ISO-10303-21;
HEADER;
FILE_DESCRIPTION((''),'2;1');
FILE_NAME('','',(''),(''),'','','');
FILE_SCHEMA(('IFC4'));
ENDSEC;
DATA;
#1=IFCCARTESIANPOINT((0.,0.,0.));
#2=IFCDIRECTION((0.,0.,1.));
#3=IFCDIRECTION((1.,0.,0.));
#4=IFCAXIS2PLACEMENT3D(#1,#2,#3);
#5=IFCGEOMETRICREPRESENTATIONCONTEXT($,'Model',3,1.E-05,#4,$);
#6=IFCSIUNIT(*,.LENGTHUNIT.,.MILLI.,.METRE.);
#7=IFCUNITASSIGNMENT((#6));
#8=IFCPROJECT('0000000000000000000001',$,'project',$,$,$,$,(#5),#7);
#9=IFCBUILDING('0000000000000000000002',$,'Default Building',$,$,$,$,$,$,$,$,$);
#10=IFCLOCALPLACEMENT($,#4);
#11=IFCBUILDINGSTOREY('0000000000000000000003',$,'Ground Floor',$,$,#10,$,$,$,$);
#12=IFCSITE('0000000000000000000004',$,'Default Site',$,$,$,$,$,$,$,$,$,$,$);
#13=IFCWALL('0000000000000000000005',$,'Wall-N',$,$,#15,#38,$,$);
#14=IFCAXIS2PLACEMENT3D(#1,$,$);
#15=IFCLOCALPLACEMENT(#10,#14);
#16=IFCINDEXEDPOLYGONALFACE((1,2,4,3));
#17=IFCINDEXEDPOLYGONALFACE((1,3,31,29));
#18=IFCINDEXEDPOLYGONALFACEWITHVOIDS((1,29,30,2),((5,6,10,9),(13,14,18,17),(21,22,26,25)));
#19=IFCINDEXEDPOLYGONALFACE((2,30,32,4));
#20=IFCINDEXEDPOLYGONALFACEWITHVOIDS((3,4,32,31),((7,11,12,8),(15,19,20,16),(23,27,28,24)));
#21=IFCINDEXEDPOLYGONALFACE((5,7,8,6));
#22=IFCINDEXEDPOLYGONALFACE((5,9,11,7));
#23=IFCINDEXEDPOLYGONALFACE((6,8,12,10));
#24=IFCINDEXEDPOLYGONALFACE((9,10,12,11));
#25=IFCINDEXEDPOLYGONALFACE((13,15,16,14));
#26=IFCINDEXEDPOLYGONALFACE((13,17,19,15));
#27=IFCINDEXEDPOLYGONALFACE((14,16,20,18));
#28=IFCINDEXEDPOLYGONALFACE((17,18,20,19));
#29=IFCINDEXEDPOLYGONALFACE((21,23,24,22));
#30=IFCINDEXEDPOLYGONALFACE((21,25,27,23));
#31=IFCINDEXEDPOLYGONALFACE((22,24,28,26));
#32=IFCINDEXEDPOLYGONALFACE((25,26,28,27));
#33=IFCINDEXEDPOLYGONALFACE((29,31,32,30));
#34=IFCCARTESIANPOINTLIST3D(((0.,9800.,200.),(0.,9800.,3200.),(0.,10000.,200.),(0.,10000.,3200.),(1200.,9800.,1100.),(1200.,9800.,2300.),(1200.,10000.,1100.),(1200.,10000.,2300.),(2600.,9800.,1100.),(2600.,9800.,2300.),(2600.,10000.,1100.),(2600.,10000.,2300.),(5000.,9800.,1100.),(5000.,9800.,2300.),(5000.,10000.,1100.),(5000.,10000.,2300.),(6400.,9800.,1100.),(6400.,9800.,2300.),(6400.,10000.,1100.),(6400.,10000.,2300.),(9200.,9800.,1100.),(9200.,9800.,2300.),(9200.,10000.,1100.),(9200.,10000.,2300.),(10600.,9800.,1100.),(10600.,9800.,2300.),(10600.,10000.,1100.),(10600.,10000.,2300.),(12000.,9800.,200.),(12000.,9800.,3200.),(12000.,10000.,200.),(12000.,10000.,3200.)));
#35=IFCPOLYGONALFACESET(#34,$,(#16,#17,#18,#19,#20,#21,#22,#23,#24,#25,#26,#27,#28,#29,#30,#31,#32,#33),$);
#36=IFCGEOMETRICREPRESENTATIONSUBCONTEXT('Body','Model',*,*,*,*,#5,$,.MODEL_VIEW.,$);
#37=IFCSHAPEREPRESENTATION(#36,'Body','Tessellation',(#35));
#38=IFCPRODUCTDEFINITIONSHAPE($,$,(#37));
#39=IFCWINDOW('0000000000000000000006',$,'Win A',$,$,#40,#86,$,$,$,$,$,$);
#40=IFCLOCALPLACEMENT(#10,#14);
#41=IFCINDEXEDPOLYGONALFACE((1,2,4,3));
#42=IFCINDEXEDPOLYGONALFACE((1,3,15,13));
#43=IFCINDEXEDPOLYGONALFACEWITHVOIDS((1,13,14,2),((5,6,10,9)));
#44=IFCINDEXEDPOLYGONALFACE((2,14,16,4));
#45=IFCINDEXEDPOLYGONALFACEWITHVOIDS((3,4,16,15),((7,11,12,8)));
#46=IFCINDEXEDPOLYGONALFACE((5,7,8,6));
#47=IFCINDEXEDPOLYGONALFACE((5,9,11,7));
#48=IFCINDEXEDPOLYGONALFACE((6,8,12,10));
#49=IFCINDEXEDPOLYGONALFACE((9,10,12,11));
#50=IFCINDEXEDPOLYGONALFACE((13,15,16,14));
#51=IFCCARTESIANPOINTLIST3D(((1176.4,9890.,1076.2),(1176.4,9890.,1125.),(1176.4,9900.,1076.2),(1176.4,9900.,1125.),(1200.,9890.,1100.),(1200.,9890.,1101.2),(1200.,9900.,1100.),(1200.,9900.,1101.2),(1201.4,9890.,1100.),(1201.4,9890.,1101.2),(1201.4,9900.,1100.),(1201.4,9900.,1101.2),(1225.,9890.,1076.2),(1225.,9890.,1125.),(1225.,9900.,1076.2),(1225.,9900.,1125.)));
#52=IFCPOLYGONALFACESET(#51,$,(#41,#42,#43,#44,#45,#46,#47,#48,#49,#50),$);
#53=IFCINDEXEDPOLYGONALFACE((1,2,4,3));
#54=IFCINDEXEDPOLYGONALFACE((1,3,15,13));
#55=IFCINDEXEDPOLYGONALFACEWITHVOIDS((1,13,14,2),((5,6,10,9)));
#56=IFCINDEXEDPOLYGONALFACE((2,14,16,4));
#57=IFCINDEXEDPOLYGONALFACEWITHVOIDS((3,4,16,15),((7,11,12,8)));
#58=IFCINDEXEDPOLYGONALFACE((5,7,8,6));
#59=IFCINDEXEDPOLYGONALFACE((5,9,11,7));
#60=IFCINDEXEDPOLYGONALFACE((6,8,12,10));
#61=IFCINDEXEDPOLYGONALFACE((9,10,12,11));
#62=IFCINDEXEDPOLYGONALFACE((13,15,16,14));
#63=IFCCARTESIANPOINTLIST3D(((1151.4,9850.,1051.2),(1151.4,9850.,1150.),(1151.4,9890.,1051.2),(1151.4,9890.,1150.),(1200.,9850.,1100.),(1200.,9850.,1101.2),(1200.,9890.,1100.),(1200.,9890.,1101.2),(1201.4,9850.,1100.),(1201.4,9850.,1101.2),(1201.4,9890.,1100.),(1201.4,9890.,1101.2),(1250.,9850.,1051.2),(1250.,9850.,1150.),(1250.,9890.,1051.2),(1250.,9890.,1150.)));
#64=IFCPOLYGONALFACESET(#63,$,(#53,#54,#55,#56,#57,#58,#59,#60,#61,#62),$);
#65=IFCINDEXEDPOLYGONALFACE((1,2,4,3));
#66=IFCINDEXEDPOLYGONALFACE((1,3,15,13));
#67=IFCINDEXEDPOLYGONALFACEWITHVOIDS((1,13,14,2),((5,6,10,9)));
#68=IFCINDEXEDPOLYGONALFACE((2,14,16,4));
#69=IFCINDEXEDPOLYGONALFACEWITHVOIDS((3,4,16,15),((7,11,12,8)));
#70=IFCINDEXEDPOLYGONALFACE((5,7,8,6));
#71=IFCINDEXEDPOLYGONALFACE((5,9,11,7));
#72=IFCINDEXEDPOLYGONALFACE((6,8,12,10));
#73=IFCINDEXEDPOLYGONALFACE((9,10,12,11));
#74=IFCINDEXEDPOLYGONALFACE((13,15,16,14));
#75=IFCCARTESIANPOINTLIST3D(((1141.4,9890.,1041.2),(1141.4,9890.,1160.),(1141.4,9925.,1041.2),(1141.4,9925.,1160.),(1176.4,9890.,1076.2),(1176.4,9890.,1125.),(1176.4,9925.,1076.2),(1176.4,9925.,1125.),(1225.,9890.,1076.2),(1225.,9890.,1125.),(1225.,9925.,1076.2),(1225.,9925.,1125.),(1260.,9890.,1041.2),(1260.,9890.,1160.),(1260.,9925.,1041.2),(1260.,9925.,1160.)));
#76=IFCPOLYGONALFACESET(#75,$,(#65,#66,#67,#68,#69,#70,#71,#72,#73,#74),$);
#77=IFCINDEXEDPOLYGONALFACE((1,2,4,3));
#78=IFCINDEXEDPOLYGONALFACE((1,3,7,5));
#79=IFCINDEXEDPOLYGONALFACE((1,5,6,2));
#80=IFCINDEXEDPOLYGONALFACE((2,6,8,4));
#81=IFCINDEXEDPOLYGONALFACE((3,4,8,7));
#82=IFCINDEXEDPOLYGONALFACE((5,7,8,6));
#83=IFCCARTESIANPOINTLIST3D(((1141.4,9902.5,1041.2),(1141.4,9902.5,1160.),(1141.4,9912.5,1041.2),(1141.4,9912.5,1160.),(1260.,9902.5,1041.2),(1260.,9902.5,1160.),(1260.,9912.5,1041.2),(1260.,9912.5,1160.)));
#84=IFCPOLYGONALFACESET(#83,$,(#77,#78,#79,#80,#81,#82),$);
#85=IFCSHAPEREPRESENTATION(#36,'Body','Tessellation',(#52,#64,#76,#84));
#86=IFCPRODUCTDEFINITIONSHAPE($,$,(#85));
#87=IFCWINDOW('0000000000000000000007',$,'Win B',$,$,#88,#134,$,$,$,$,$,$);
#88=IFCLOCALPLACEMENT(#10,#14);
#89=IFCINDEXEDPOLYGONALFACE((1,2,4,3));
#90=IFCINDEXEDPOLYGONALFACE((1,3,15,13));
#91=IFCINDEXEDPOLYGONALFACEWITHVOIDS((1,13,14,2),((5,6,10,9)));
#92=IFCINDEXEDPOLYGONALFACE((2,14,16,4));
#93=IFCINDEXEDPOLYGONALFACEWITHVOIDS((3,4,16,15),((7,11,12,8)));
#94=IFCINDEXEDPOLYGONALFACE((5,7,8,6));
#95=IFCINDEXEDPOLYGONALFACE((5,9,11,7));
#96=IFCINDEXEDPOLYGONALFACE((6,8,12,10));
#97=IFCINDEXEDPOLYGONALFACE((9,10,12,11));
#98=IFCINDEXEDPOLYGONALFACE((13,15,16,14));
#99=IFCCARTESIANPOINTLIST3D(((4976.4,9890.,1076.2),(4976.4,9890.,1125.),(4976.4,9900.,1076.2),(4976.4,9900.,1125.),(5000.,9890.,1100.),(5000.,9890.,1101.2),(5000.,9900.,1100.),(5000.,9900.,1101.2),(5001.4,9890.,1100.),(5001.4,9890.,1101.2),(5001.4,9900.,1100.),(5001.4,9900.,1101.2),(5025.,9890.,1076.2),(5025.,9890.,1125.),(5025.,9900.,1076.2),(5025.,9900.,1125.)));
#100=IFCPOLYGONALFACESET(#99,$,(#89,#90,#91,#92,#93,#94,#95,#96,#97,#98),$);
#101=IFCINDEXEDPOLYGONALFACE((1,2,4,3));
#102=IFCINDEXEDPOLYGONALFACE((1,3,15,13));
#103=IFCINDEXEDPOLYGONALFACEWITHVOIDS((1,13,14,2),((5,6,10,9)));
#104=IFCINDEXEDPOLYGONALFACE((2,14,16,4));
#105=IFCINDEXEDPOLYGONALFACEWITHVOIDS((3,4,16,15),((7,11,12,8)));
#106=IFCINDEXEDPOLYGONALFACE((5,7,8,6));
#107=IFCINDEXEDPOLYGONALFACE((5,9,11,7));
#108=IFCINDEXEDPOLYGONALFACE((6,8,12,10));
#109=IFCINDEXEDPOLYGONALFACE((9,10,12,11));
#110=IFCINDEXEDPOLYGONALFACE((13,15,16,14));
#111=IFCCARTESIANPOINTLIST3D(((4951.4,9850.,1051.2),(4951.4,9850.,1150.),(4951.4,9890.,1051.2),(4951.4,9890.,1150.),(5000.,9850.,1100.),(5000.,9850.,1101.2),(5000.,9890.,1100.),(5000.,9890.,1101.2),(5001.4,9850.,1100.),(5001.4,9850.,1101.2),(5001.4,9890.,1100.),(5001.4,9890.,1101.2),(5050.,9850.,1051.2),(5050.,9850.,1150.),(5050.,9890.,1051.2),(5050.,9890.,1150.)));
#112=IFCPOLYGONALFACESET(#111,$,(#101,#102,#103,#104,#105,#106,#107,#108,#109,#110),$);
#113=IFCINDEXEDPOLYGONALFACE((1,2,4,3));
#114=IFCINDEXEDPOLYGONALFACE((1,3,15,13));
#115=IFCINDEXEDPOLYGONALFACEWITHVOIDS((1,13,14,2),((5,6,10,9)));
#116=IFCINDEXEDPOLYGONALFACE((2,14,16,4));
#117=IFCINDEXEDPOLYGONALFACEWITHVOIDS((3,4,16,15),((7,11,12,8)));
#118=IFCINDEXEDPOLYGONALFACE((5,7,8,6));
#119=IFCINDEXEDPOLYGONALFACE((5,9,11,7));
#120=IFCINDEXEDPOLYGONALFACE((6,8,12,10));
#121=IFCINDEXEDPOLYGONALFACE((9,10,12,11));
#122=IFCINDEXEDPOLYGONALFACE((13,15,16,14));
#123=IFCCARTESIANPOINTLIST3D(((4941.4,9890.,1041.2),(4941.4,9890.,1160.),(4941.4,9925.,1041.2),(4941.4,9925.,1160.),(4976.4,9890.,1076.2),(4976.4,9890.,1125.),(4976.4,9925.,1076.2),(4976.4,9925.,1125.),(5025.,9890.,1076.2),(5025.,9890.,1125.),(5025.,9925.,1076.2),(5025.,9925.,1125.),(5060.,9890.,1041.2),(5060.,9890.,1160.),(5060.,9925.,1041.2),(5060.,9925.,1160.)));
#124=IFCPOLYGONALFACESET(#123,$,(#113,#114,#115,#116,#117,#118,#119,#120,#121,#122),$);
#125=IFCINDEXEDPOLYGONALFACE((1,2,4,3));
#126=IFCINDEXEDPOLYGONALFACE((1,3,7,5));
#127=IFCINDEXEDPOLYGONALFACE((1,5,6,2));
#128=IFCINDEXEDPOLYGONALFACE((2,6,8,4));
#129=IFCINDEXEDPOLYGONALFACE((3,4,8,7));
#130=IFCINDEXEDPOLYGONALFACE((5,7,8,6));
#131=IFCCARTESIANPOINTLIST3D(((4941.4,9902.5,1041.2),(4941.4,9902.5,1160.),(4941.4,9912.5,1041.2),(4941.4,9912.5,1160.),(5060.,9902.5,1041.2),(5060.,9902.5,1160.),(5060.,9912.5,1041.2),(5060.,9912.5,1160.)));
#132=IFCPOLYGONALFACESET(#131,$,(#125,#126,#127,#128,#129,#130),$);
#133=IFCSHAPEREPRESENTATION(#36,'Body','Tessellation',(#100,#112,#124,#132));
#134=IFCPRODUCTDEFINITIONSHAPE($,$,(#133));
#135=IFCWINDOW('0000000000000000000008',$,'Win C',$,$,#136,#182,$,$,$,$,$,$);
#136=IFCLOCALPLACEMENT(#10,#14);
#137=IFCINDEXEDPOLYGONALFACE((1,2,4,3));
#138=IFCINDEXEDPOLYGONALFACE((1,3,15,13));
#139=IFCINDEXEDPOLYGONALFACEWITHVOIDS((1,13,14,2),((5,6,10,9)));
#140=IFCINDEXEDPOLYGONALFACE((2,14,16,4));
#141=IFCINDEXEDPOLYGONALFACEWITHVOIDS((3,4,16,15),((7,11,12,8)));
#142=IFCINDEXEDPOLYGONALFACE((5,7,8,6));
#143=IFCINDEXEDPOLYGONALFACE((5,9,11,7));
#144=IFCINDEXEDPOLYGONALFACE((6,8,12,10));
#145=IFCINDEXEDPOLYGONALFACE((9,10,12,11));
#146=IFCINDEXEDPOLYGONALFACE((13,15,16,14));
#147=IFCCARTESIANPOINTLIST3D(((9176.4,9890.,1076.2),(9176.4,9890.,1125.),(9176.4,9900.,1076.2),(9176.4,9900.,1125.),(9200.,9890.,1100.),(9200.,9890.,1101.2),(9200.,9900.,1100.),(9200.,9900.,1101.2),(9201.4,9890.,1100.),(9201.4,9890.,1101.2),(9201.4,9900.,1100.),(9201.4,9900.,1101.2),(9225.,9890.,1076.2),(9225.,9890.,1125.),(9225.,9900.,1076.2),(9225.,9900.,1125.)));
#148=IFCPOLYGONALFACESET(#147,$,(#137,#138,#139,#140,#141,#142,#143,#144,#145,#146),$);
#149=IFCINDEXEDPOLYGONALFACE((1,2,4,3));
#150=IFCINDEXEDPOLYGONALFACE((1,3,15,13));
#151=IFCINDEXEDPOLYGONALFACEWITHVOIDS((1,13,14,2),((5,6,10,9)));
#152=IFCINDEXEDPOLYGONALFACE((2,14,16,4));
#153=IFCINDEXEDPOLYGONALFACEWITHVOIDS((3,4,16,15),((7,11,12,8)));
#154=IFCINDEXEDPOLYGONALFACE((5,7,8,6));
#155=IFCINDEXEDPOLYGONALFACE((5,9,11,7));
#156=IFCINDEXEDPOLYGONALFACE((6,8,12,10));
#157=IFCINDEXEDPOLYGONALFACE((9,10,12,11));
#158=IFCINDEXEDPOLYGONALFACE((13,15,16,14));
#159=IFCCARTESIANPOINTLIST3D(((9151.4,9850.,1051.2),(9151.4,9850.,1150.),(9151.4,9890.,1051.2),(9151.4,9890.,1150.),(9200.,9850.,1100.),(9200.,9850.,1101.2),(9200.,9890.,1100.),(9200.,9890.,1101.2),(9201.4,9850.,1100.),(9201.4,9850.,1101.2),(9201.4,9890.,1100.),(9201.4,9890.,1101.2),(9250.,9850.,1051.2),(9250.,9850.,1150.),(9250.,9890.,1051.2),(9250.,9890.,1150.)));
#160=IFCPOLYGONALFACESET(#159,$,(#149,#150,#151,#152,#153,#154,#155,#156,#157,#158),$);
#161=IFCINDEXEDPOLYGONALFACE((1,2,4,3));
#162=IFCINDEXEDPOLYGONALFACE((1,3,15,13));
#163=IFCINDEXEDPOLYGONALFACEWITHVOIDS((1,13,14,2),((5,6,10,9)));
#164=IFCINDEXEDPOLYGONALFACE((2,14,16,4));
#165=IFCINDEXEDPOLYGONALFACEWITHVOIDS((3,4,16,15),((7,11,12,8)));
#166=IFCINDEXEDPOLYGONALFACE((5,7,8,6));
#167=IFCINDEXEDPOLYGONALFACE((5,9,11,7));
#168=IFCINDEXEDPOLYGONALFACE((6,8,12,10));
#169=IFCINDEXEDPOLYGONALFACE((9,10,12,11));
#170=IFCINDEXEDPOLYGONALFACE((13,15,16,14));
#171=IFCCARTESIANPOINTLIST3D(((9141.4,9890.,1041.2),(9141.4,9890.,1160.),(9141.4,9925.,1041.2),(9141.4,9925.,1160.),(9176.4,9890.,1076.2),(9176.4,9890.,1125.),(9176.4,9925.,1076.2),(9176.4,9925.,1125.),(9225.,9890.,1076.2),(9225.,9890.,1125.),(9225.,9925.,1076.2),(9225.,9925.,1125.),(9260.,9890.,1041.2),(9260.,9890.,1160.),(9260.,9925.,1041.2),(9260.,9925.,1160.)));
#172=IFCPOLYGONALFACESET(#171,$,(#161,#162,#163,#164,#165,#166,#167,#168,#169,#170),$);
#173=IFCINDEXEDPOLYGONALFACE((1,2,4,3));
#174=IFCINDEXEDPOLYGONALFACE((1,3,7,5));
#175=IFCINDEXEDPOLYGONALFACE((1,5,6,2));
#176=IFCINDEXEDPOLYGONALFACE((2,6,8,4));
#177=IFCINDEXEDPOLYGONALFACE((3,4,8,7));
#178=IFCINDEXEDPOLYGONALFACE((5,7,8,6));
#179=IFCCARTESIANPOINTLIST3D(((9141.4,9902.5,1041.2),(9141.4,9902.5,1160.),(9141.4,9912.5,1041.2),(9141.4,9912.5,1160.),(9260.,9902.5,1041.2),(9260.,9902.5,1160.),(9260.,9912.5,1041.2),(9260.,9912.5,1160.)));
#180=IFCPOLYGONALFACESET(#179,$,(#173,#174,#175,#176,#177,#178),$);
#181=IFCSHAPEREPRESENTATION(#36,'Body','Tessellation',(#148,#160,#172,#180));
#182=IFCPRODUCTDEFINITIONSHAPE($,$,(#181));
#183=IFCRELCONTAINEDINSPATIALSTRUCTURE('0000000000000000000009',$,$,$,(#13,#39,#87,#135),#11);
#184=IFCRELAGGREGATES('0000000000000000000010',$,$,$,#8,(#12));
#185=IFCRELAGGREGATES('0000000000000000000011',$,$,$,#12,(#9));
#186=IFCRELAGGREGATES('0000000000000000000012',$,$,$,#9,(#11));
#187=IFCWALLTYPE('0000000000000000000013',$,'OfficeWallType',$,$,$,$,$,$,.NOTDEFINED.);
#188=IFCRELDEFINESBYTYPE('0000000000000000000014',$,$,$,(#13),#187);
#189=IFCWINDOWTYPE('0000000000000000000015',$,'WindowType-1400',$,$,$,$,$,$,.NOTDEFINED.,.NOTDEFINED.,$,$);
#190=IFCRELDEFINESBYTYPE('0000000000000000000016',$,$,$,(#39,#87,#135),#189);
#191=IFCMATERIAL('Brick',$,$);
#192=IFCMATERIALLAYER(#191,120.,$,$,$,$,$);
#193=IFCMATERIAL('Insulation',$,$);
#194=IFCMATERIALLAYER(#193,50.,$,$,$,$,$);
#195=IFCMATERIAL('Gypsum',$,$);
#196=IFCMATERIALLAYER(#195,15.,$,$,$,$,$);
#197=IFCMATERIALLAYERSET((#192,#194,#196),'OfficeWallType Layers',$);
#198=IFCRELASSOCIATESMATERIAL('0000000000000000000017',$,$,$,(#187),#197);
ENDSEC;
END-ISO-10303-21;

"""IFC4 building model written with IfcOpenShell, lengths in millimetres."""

from ifc_helpers import new_model, si_unit, frame, origin_with_axes, place, context, subcontext, project, spatial, line, indexed_curve, outline, extrude, material, layer, layer_set, type_object, element, fill, save


model = new_model("IFC4")

# Units and contexts
model_context = context("Model", 3, precision=1e-05, world=origin_with_axes())
body_context = subcontext(model_context, "Body", "Model", "MODEL_VIEW")
ifc_project = project(units=[si_unit("LENGTHUNIT", "METRE", prefix="MILLI")], contexts=[model_context])

# Site, building, storey
site = spatial("IfcSite", under=ifc_project, Name="Default Site")
building = spatial("IfcBuilding", under=site, Name="Default Building")
storey_placement = place(None, origin_with_axes())
storey = spatial("IfcBuildingStorey", under=building, at=storey_placement, Name="Ground Floor")

# Shared definitions
ifc_material_1 = material(Name="Brick")
ifc_layer_1 = layer(ifc_material_1, 120.0)
ifc_material_2 = material(Name="Insulation")
ifc_layer_2 = layer(ifc_material_2, 50.0)
ifc_material_3 = material(Name="Gypsum")
ifc_layer_3 = layer(ifc_material_3, 15.0)
ifc_layer_set_1 = layer_set([ifc_layer_1, ifc_layer_2, ifc_layer_3], Name="OfficeWallType Layers")
wall_type = type_object("IfcWallType", Name="OfficeWallType", PredefinedType="NOTDEFINED", material=ifc_layer_set_1)

# Wall, openings, windows
wall_1_placement = place(storey_placement, frame((0.0, 0.0, 200.0), z_axis=(0.0, 0.0, 1.0), x_axis=(1.0, 0.0, 0.0)))
wall_1 = element("IfcWall", 1, at=wall_1_placement, inside=storey, type_object=wall_type, Name="Wall-N", context=body_context, shape_type="SweptSolid", body=[
    extrude(outline(indexed_curve([(0.0, 9800.0), (12000.0, 9800.0), (12000.0, 10000.0), (0.0, 10000.0), (0.0, 9800.0)])), None, (0.0, 0.0, 1.0), 3000.0),
])
opening_1_placement = place(wall_1_placement, frame((0.0, 0.0, 900.0), z_axis=(0.0, 0.0, 1.0), x_axis=(1.0, 0.0, 0.0)))
opening_1 = element("IfcOpeningElement", 2, at=opening_1_placement, cuts=wall_1, context=body_context, shape_type="SweptSolid", body=[
    extrude(outline(indexed_curve([(1200.0, 9800.0), (2600.0, 9800.0), (2600.0, 10000.0), (1200.0, 10000.0), (1200.0, 9800.0)])), None, (0.0, 0.0, 1.0), 1200.0),
])
opening_2_placement = place(wall_1_placement, frame((0.0, 0.0, 900.0), z_axis=(0.0, 0.0, 1.0), x_axis=(1.0, 0.0, 0.0)))
opening_2 = element("IfcOpeningElement", 3, at=opening_2_placement, cuts=wall_1, context=body_context, shape_type="SweptSolid", body=[
    extrude(outline(indexed_curve([(5000.0, 9800.0), (6400.0, 9800.0), (6400.0, 10000.0), (5000.0, 10000.0), (5000.0, 9800.0)])), None, (0.0, 0.0, 1.0), 1200.0),
])
opening_3_placement = place(wall_1_placement, frame((0.0, 0.0, 900.0), z_axis=(0.0, 0.0, 1.0), x_axis=(1.0, 0.0, 0.0)))
opening_3 = element("IfcOpeningElement", 4, at=opening_3_placement, cuts=wall_1, context=body_context, shape_type="SweptSolid", body=[
    extrude(outline(indexed_curve([(9200.0, 9800.0), (10600.0, 9800.0), (10600.0, 10000.0), (9200.0, 10000.0), (9200.0, 9800.0)])), None, (0.0, 0.0, 1.0), 1200.0),
])
window_type = type_object("IfcWindowType", Name="WindowType-1400", PartitioningType="NOTDEFINED", PredefinedType="NOTDEFINED")
window_1_placement = place(storey_placement, frame((1200.0, 9800.0, 1100.0), z_axis=(0.0, 0.0, 1.0), x_axis=(1.0, 0.0, 0.0)))
window_1 = element("IfcWindow", 5, at=window_1_placement, inside=storey, type_object=window_type, Name="Win A", context=body_context, shape_type="SweptSolid", body=[
    extrude(outline(indexed_curve([(0.0, 0.0), (1.4, 0.0), (1.4, 1.2), (0.0, 1.2)], segments=[line(1, 2, 3, 4, 1)]), holes=[indexed_curve([(25.0, 25.0), (-23.6, 25.0), (-23.6, -23.8), (25.0, -23.8)], segments=[line(1, 2, 3, 4, 1)])]), frame((0.0, 90.0, 0.0), z_axis=(0.0, -1.0, 0.0), x_axis=(1.0, 0.0, 0.0)), (0.0, 0.0, -1.0), 10.0),
    extrude(outline(indexed_curve([(0.0, 0.0), (1.4, 0.0), (1.4, 1.2), (0.0, 1.2)], segments=[line(1, 2, 3, 4, 1)]), holes=[indexed_curve([(50.0, 50.0), (-48.6, 50.0), (-48.6, -48.8), (50.0, -48.8)], segments=[line(1, 2, 3, 4, 1)])]), frame((0.0, 50.0, 0.0), z_axis=(0.0, -1.0, 0.0), x_axis=(1.0, 0.0, 0.0)), (0.0, 0.0, -1.0), 40.0),
    extrude(outline(indexed_curve([(0.0, 0.0), (-48.6, 0.0), (-48.6, -48.8), (0.0, -48.8)], segments=[line(1, 2, 3, 4, 1)]), holes=[indexed_curve([(35.0, 35.0), (-83.6, 35.0), (-83.6, -83.8), (35.0, -83.8)], segments=[line(1, 2, 3, 4, 1)])]), frame((25.0, 90.0, 25.0), z_axis=(0.0, -1.0, 0.0), x_axis=(1.0, 0.0, 0.0)), (0.0, 0.0, -1.0), 35.0),
    extrude(outline(indexed_curve([(35.0, 35.0), (-83.6, 35.0), (-83.6, -83.8), (35.0, -83.8)], segments=[line(1, 2, 3, 4, 1)])), frame((25.0, 102.5, 25.0), z_axis=(0.0, -1.0, 0.0), x_axis=(1.0, 0.0, 0.0)), (0.0, 0.0, -1.0), 10.0),
])
fill(opening_1, window_1)
window_2_placement = place(storey_placement, frame((5000.0, 9800.0, 1100.0), z_axis=(0.0, 0.0, 1.0), x_axis=(1.0, 0.0, 0.0)))
window_2 = element("IfcWindow", 6, at=window_2_placement, inside=storey, type_object=window_type, Name="Win B", context=body_context, shape_type="SweptSolid", body=[
    extrude(outline(indexed_curve([(0.0, 0.0), (1.4, 0.0), (1.4, 1.2), (0.0, 1.2)], segments=[line(1, 2, 3, 4, 1)]), holes=[indexed_curve([(25.0, 25.0), (-23.6, 25.0), (-23.6, -23.8), (25.0, -23.8)], segments=[line(1, 2, 3, 4, 1)])]), frame((0.0, 90.0, 0.0), z_axis=(0.0, -1.0, 0.0), x_axis=(1.0, 0.0, 0.0)), (0.0, 0.0, -1.0), 10.0),
    extrude(outline(indexed_curve([(0.0, 0.0), (1.4, 0.0), (1.4, 1.2), (0.0, 1.2)], segments=[line(1, 2, 3, 4, 1)]), holes=[indexed_curve([(50.0, 50.0), (-48.6, 50.0), (-48.6, -48.8), (50.0, -48.8)], segments=[line(1, 2, 3, 4, 1)])]), frame((0.0, 50.0, 0.0), z_axis=(0.0, -1.0, 0.0), x_axis=(1.0, 0.0, 0.0)), (0.0, 0.0, -1.0), 40.0),
    extrude(outline(indexed_curve([(0.0, 0.0), (-48.6, 0.0), (-48.6, -48.8), (0.0, -48.8)], segments=[line(1, 2, 3, 4, 1)]), holes=[indexed_curve([(35.0, 35.0), (-83.6, 35.0), (-83.6, -83.8), (35.0, -83.8)], segments=[line(1, 2, 3, 4, 1)])]), frame((25.0, 90.0, 25.0), z_axis=(0.0, -1.0, 0.0), x_axis=(1.0, 0.0, 0.0)), (0.0, 0.0, -1.0), 35.0),
    extrude(outline(indexed_curve([(35.0, 35.0), (-83.6, 35.0), (-83.6, -83.8), (35.0, -83.8)], segments=[line(1, 2, 3, 4, 1)])), frame((25.0, 102.5, 25.0), z_axis=(0.0, -1.0, 0.0), x_axis=(1.0, 0.0, 0.0)), (0.0, 0.0, -1.0), 10.0),
])
fill(opening_2, window_2)
window_3_placement = place(storey_placement, frame((9200.0, 9800.0, 1100.0), z_axis=(0.0, 0.0, 1.0), x_axis=(1.0, 0.0, 0.0)))
window_3 = element("IfcWindow", 7, at=window_3_placement, inside=storey, type_object=window_type, Name="Win C", context=body_context, shape_type="SweptSolid", body=[
    extrude(outline(indexed_curve([(0.0, 0.0), (1.4, 0.0), (1.4, 1.2), (0.0, 1.2)], segments=[line(1, 2, 3, 4, 1)]), holes=[indexed_curve([(25.0, 25.0), (-23.6, 25.0), (-23.6, -23.8), (25.0, -23.8)], segments=[line(1, 2, 3, 4, 1)])]), frame((0.0, 90.0, 0.0), z_axis=(0.0, -1.0, 0.0), x_axis=(1.0, 0.0, 0.0)), (0.0, 0.0, -1.0), 10.0),
    extrude(outline(indexed_curve([(0.0, 0.0), (1.4, 0.0), (1.4, 1.2), (0.0, 1.2)], segments=[line(1, 2, 3, 4, 1)]), holes=[indexed_curve([(50.0, 50.0), (-48.6, 50.0), (-48.6, -48.8), (50.0, -48.8)], segments=[line(1, 2, 3, 4, 1)])]), frame((0.0, 50.0, 0.0), z_axis=(0.0, -1.0, 0.0), x_axis=(1.0, 0.0, 0.0)), (0.0, 0.0, -1.0), 40.0),
    extrude(outline(indexed_curve([(0.0, 0.0), (-48.6, 0.0), (-48.6, -48.8), (0.0, -48.8)], segments=[line(1, 2, 3, 4, 1)]), holes=[indexed_curve([(35.0, 35.0), (-83.6, 35.0), (-83.6, -83.8), (35.0, -83.8)], segments=[line(1, 2, 3, 4, 1)])]), frame((25.0, 90.0, 25.0), z_axis=(0.0, -1.0, 0.0), x_axis=(1.0, 0.0, 0.0)), (0.0, 0.0, -1.0), 35.0),
    extrude(outline(indexed_curve([(35.0, 35.0), (-83.6, 35.0), (-83.6, -83.8), (35.0, -83.8)], segments=[line(1, 2, 3, 4, 1)])), frame((25.0, 102.5, 25.0), z_axis=(0.0, -1.0, 0.0), x_axis=(1.0, 0.0, 0.0)), (0.0, 0.0, -1.0), 10.0),
])
fill(opening_3, window_3)

save(model, "model.ifc")
